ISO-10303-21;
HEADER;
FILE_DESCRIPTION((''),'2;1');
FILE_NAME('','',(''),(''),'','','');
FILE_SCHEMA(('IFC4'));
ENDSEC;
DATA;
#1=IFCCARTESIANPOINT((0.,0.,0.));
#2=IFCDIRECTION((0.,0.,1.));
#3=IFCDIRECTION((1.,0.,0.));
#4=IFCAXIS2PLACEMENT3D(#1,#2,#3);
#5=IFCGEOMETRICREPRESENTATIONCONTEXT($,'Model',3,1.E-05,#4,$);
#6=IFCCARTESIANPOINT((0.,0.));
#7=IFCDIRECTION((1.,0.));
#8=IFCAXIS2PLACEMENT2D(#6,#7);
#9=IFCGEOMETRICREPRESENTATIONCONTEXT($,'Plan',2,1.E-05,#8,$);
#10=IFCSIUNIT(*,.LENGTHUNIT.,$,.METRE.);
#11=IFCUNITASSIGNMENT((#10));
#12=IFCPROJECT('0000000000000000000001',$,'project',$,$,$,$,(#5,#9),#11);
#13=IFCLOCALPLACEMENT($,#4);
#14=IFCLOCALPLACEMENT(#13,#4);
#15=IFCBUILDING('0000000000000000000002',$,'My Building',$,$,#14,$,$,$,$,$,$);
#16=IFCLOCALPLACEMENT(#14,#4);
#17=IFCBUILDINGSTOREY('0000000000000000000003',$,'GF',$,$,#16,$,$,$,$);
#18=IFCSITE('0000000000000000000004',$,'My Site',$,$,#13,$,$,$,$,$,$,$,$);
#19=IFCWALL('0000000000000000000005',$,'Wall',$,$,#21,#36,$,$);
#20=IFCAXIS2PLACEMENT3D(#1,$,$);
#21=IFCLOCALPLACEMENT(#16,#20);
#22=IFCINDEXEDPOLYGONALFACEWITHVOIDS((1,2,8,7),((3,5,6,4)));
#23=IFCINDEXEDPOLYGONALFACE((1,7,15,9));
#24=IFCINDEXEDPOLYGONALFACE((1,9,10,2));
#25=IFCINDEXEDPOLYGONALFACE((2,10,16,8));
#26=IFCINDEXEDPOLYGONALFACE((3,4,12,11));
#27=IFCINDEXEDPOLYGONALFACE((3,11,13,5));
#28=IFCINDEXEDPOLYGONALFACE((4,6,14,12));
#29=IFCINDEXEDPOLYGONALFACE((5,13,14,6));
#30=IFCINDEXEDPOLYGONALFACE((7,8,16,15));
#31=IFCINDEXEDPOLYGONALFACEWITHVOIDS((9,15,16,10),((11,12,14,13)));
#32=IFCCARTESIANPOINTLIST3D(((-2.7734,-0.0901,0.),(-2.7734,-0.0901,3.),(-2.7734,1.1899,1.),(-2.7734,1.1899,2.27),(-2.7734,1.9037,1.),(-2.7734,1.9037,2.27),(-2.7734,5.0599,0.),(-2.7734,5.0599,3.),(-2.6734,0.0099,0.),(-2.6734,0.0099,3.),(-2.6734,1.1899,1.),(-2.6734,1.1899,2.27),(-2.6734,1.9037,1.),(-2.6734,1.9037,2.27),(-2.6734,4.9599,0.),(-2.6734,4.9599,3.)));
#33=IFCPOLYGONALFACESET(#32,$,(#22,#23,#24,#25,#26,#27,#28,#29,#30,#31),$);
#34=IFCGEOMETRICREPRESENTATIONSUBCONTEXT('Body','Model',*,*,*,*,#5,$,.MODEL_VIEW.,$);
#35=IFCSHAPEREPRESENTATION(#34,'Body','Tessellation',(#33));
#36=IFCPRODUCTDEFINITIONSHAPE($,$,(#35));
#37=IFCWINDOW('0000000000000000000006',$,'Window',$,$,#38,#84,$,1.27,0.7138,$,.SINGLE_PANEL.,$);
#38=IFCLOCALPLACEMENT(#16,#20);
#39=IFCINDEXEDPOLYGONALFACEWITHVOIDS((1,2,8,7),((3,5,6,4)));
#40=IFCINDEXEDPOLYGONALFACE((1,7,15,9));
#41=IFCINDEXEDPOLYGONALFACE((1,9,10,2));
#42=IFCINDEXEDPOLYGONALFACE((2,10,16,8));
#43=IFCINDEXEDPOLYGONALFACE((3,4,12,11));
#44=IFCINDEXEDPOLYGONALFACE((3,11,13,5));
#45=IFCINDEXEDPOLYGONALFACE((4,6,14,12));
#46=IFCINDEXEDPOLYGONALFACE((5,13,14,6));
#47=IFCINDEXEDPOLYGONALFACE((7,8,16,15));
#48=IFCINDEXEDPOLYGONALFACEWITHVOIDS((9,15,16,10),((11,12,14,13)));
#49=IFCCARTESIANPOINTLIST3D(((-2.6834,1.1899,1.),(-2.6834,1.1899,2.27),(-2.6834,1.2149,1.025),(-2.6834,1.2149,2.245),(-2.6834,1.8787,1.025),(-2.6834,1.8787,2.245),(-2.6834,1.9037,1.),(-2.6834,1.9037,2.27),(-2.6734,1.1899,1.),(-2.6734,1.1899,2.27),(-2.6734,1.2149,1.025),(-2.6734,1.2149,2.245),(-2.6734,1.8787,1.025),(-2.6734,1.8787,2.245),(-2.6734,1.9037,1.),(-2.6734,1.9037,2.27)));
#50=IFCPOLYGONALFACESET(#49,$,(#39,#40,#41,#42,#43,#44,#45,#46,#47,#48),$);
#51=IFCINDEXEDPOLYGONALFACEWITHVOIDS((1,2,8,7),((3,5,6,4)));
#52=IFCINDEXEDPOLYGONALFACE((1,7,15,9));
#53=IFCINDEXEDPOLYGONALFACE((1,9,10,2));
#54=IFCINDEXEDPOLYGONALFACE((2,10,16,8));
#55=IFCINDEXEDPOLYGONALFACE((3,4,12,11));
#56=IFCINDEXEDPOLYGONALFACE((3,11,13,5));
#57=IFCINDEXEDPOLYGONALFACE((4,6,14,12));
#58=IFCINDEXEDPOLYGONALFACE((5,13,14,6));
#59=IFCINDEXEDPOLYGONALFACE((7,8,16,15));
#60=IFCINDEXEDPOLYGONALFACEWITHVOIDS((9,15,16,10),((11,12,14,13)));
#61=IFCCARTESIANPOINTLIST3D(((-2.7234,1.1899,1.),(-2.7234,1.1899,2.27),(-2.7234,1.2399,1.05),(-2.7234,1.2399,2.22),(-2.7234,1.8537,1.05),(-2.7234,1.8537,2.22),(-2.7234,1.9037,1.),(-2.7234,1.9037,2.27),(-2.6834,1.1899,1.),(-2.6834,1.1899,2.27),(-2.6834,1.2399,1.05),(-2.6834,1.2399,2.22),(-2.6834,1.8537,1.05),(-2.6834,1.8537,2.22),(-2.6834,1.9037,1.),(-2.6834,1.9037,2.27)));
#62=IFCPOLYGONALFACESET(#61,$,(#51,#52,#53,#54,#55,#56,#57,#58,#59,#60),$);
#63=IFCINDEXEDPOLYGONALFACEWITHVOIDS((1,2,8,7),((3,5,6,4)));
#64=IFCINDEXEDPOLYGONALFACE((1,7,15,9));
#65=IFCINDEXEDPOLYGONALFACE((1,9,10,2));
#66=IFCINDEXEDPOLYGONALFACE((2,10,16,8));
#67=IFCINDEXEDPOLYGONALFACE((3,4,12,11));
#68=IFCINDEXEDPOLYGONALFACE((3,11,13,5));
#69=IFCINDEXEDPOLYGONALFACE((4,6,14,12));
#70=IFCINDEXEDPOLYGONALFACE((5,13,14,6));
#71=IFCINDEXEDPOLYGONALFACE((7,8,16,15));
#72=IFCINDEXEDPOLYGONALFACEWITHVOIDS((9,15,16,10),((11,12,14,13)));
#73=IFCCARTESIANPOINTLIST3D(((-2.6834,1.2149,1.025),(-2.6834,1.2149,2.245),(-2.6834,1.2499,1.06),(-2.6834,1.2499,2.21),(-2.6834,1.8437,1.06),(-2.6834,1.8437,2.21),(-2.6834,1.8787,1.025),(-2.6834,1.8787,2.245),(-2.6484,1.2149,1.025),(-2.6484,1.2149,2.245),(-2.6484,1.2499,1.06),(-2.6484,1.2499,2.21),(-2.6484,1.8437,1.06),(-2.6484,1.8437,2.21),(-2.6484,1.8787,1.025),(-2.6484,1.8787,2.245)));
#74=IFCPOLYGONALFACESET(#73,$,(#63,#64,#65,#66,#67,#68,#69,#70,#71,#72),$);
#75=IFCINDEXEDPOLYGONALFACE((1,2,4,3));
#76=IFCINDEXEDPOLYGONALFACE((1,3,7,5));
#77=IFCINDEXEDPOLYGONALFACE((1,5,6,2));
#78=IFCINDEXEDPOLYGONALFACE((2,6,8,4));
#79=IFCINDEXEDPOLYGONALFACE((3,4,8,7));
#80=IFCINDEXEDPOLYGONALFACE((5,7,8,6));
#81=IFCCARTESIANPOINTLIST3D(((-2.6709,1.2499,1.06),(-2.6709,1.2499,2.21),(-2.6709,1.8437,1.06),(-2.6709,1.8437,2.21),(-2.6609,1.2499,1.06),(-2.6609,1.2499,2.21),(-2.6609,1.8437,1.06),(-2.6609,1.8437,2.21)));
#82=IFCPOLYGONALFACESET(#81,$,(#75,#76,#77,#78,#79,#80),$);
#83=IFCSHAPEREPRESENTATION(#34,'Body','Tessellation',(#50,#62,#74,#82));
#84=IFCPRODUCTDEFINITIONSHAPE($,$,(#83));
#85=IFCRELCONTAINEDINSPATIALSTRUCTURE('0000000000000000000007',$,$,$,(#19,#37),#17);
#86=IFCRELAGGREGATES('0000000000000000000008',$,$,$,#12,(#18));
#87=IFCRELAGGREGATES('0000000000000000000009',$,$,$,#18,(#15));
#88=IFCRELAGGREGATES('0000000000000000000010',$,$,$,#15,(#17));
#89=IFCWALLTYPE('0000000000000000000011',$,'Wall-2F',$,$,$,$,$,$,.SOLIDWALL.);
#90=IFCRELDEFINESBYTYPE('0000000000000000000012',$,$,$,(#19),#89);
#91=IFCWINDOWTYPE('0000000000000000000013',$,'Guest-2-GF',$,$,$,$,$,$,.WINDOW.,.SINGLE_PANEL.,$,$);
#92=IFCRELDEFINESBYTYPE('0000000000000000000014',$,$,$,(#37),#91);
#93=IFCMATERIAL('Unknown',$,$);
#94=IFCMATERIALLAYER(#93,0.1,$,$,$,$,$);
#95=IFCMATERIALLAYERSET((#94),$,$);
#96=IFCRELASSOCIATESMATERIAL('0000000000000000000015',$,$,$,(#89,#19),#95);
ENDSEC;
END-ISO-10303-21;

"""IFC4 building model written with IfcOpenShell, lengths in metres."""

from ifc_helpers import new_model, entity, si_unit, frame, origin_with_axes, origin_2d_with_axis, place, context, subcontext, project, spatial, line, indexed_curve, outline, extrude, shape, source, transform, mapped, material, layer, layer_set, layer_usage, type_object, type_shapes, element, fill, save


model = new_model("IFC4")

# Units and contexts
model_context = context("Model", 3, precision=1e-05, world=origin_with_axes())
plan_context = context("Plan", 2, precision=1e-05, world=origin_2d_with_axis())
body_context_1 = subcontext(model_context, "Body", "Model", "MODEL_VIEW")
body_context_2 = subcontext(plan_context, "Body", "Plan", "PLAN_VIEW")
ifc_project = project(units=[si_unit("LENGTHUNIT", "METRE")], contexts=[model_context, plan_context])

# Site, building, storey
site_placement = place(None, origin_with_axes())
site = spatial("IfcSite", under=ifc_project, at=site_placement, Name="My Site")
building_placement = place(site_placement, origin_with_axes())
building = spatial("IfcBuilding", under=site, at=building_placement, Name="My Building")
storey_placement = place(building_placement, origin_with_axes())
storey = spatial("IfcBuildingStorey", under=building, at=storey_placement, Name="GF")

# Shared definitions
ifc_material = material(Name="Unknown")

# Shared definitions
ifc_layer_1 = layer(ifc_material, 0.1)
ifc_layer_set_1 = layer_set([ifc_layer_1])
wall_type = type_object("IfcWallType", Name="Wall-2F", PredefinedType="SOLIDWALL", material=ifc_layer_set_1)

# Wall, opening, window
ifc_layer_usage_1 = layer_usage(ifc_layer_set_1, "AXIS2", "POSITIVE", 0.0)
wall_1_placement = place(storey_placement, frame((-2.7734, 5.0599, 0.0), z_axis=(0.0, 0.0, 1.0), x_axis=(0.0, -1.0, 0.0)))
wall_1 = element("IfcWall", 1, at=wall_1_placement, inside=storey, type_object=wall_type, material=ifc_layer_usage_1, Name="Wall", context=body_context_1, shape_type="SweptSolid", body=[
    extrude(outline(indexed_curve([(0.0, 0.0), (0.1, 0.1), (5.05, 0.1), (5.15, 0.0)], segments=[line(1, 2, 3, 4, 1)])), origin_with_axes(), (0.0, 0.0, 1.0), 3.0),
])
shared_shape_1 = source(origin_with_axes(), body_context_1, "Body", "SweptSolid", [
    extrude(outline(indexed_curve([(0.0, 0.0), (0.7138, 0.0), (0.7138, 1.27), (0.0, 1.27)], segments=[line(1, 2, 3, 4, 1)])), frame((0.0, -0.6, 0.0), z_axis=(0.0, -1.0, 0.0), x_axis=(1.0, 0.0, 0.0)), (0.0, 0.0, -1.0), 1.2),
])
opening_1_placement = place(wall_1_placement, frame((3.1562, 0.0, 1.0), z_axis=(0.0, 0.0, 1.0), x_axis=(1.0, 0.0, 0.0)))
opening_1 = element("IfcOpeningElement", 2, at=opening_1_placement, cuts=wall_1, PredefinedType="OPENING", context=body_context_1, shape_type="MappedRepresentation", body=[
    mapped(shared_shape_1, transform((0.0, 0.0, 0.0), x_axis=(1.0, 0.0, 0.0), y_axis=(0.0, 1.0, 0.0), z_axis=(0.0, 0.0, 1.0), scale=1.0)),
])
window_type_1 = type_object("IfcWindowType", Name="Guest-2-GF", PartitioningType="SINGLE_PANEL", PredefinedType="WINDOW")
shared_shape_2 = source(origin_with_axes(), body_context_1, "Body", "SweptSolid", [
    extrude(outline(indexed_curve([(0.0, 0.0), (0.7138, 0.0), (0.7138, 1.27), (0.0, 1.27)], segments=[line(1, 2, 3, 4, 1)]), holes=[indexed_curve([(0.025, 0.025), (0.6888, 0.025), (0.6888, 1.245), (0.025, 1.245)], segments=[line(1, 2, 3, 4, 1)])]), frame((0.0, 0.09, 0.0), z_axis=(0.0, -1.0, 0.0), x_axis=(1.0, 0.0, 0.0)), (0.0, 0.0, -1.0), 0.01),
    extrude(outline(indexed_curve([(0.0, 0.0), (0.7138, 0.0), (0.7138, 1.27), (0.0, 1.27)], segments=[line(1, 2, 3, 4, 1)]), holes=[indexed_curve([(0.05, 0.05), (0.6638, 0.05), (0.6638, 1.22), (0.05, 1.22)], segments=[line(1, 2, 3, 4, 1)])]), frame((0.0, 0.05, 0.0), z_axis=(0.0, -1.0, 0.0), x_axis=(1.0, 0.0, 0.0)), (0.0, 0.0, -1.0), 0.04),
    extrude(outline(indexed_curve([(0.0, 0.0), (0.6638, 0.0), (0.6638, 1.22), (0.0, 1.22)], segments=[line(1, 2, 3, 4, 1)]), holes=[indexed_curve([(0.035, 0.035), (0.6288, 0.035), (0.6288, 1.185), (0.035, 1.185)], segments=[line(1, 2, 3, 4, 1)])]), frame((0.025, 0.09, 0.025), z_axis=(0.0, -1.0, 0.0), x_axis=(1.0, 0.0, 0.0)), (0.0, 0.0, -1.0), 0.035),
    extrude(outline(indexed_curve([(0.035, 0.035), (0.6288, 0.035), (0.6288, 1.185), (0.035, 1.185)], segments=[line(1, 2, 3, 4, 1)])), frame((0.025, 0.1025, 0.025), z_axis=(0.0, -1.0, 0.0), x_axis=(1.0, 0.0, 0.0)), (0.0, 0.0, -1.0), 0.01),
])
shared_shape_3 = source(origin_with_axes(), body_context_2, "Body", "Curve2D", [
    entity("IfcIndexedPolyCurve", entity("IfcCartesianPointList2D", [[0.05, 0.05], [0.6638, 0.05]])),
    entity("IfcIndexedPolyCurve", entity("IfcCartesianPointList2D", [[0.0, 0.1], [0.025, 0.1], [0.025, 0.09], [0.05, 0.09], [0.05, 0.05], [0.0, 0.05]]), [entity("IfcLineIndex", [1, 2, 3, 4, 5, 6, 1])]),
    entity("IfcIndexedPolyCurve", entity("IfcCartesianPointList2D", [[0.7138, 0.1], [0.6888, 0.1], [0.6888, 0.09], [0.6638, 0.09], [0.6638, 0.05], [0.7138, 0.05]]), [entity("IfcLineIndex", [1, 2, 3, 4, 5, 6, 1])]),
    entity("IfcIndexedPolyCurve", entity("IfcCartesianPointList2D", [[0.025, 0.09], [0.06, 0.09], [0.06, 0.125], [0.025, 0.125]]), [entity("IfcLineIndex", [1, 2, 3, 4, 1])]),
    entity("IfcIndexedPolyCurve", entity("IfcCartesianPointList2D", [[0.6888, 0.09], [0.6538, 0.09], [0.6538, 0.125], [0.6888, 0.125]]), [entity("IfcLineIndex", [1, 2, 3, 4, 1])]),
    entity("IfcIndexedPolyCurve", entity("IfcCartesianPointList2D", [[0.06, 0.09], [0.6538, 0.09]])),
    entity("IfcIndexedPolyCurve", entity("IfcCartesianPointList2D", [[0.06, 0.125], [0.6538, 0.125]])),
    entity("IfcIndexedPolyCurve", entity("IfcCartesianPointList2D", [[0.06, 0.1075], [0.6538, 0.1075]])),
])
type_shapes(window_type_1, [shared_shape_2, shared_shape_3])
window_1_placement = place(opening_1_placement, frame((0.0, 0.0, 0.0), z_axis=(0.0, 0.0, 1.0), x_axis=(1.0, 0.0, 0.0)))
window_1 = element("IfcWindow", 3, at=window_1_placement, inside=storey, type_object=window_type_1, Name="Window", OverallHeight=1.27, OverallWidth=0.7138, PartitioningType="SINGLE_PANEL", shapes=[
    shape(body_context_1, "Body", "MappedRepresentation", [mapped(shared_shape_2, transform((0.0, 0.0, 0.0), x_axis=(1.0, 0.0, 0.0), y_axis=(0.0, 1.0, 0.0), z_axis=(0.0, 0.0, 1.0), scale=1.0))]),
    shape(body_context_2, "Body", "MappedRepresentation", [mapped(shared_shape_3, transform((0.0, 0.0, 0.0), x_axis=(1.0, 0.0, 0.0), y_axis=(0.0, 1.0, 0.0), z_axis=(0.0, 0.0, 1.0), scale=1.0))]),
])
fill(opening_1, window_1)

save(model, "model.ifc")
